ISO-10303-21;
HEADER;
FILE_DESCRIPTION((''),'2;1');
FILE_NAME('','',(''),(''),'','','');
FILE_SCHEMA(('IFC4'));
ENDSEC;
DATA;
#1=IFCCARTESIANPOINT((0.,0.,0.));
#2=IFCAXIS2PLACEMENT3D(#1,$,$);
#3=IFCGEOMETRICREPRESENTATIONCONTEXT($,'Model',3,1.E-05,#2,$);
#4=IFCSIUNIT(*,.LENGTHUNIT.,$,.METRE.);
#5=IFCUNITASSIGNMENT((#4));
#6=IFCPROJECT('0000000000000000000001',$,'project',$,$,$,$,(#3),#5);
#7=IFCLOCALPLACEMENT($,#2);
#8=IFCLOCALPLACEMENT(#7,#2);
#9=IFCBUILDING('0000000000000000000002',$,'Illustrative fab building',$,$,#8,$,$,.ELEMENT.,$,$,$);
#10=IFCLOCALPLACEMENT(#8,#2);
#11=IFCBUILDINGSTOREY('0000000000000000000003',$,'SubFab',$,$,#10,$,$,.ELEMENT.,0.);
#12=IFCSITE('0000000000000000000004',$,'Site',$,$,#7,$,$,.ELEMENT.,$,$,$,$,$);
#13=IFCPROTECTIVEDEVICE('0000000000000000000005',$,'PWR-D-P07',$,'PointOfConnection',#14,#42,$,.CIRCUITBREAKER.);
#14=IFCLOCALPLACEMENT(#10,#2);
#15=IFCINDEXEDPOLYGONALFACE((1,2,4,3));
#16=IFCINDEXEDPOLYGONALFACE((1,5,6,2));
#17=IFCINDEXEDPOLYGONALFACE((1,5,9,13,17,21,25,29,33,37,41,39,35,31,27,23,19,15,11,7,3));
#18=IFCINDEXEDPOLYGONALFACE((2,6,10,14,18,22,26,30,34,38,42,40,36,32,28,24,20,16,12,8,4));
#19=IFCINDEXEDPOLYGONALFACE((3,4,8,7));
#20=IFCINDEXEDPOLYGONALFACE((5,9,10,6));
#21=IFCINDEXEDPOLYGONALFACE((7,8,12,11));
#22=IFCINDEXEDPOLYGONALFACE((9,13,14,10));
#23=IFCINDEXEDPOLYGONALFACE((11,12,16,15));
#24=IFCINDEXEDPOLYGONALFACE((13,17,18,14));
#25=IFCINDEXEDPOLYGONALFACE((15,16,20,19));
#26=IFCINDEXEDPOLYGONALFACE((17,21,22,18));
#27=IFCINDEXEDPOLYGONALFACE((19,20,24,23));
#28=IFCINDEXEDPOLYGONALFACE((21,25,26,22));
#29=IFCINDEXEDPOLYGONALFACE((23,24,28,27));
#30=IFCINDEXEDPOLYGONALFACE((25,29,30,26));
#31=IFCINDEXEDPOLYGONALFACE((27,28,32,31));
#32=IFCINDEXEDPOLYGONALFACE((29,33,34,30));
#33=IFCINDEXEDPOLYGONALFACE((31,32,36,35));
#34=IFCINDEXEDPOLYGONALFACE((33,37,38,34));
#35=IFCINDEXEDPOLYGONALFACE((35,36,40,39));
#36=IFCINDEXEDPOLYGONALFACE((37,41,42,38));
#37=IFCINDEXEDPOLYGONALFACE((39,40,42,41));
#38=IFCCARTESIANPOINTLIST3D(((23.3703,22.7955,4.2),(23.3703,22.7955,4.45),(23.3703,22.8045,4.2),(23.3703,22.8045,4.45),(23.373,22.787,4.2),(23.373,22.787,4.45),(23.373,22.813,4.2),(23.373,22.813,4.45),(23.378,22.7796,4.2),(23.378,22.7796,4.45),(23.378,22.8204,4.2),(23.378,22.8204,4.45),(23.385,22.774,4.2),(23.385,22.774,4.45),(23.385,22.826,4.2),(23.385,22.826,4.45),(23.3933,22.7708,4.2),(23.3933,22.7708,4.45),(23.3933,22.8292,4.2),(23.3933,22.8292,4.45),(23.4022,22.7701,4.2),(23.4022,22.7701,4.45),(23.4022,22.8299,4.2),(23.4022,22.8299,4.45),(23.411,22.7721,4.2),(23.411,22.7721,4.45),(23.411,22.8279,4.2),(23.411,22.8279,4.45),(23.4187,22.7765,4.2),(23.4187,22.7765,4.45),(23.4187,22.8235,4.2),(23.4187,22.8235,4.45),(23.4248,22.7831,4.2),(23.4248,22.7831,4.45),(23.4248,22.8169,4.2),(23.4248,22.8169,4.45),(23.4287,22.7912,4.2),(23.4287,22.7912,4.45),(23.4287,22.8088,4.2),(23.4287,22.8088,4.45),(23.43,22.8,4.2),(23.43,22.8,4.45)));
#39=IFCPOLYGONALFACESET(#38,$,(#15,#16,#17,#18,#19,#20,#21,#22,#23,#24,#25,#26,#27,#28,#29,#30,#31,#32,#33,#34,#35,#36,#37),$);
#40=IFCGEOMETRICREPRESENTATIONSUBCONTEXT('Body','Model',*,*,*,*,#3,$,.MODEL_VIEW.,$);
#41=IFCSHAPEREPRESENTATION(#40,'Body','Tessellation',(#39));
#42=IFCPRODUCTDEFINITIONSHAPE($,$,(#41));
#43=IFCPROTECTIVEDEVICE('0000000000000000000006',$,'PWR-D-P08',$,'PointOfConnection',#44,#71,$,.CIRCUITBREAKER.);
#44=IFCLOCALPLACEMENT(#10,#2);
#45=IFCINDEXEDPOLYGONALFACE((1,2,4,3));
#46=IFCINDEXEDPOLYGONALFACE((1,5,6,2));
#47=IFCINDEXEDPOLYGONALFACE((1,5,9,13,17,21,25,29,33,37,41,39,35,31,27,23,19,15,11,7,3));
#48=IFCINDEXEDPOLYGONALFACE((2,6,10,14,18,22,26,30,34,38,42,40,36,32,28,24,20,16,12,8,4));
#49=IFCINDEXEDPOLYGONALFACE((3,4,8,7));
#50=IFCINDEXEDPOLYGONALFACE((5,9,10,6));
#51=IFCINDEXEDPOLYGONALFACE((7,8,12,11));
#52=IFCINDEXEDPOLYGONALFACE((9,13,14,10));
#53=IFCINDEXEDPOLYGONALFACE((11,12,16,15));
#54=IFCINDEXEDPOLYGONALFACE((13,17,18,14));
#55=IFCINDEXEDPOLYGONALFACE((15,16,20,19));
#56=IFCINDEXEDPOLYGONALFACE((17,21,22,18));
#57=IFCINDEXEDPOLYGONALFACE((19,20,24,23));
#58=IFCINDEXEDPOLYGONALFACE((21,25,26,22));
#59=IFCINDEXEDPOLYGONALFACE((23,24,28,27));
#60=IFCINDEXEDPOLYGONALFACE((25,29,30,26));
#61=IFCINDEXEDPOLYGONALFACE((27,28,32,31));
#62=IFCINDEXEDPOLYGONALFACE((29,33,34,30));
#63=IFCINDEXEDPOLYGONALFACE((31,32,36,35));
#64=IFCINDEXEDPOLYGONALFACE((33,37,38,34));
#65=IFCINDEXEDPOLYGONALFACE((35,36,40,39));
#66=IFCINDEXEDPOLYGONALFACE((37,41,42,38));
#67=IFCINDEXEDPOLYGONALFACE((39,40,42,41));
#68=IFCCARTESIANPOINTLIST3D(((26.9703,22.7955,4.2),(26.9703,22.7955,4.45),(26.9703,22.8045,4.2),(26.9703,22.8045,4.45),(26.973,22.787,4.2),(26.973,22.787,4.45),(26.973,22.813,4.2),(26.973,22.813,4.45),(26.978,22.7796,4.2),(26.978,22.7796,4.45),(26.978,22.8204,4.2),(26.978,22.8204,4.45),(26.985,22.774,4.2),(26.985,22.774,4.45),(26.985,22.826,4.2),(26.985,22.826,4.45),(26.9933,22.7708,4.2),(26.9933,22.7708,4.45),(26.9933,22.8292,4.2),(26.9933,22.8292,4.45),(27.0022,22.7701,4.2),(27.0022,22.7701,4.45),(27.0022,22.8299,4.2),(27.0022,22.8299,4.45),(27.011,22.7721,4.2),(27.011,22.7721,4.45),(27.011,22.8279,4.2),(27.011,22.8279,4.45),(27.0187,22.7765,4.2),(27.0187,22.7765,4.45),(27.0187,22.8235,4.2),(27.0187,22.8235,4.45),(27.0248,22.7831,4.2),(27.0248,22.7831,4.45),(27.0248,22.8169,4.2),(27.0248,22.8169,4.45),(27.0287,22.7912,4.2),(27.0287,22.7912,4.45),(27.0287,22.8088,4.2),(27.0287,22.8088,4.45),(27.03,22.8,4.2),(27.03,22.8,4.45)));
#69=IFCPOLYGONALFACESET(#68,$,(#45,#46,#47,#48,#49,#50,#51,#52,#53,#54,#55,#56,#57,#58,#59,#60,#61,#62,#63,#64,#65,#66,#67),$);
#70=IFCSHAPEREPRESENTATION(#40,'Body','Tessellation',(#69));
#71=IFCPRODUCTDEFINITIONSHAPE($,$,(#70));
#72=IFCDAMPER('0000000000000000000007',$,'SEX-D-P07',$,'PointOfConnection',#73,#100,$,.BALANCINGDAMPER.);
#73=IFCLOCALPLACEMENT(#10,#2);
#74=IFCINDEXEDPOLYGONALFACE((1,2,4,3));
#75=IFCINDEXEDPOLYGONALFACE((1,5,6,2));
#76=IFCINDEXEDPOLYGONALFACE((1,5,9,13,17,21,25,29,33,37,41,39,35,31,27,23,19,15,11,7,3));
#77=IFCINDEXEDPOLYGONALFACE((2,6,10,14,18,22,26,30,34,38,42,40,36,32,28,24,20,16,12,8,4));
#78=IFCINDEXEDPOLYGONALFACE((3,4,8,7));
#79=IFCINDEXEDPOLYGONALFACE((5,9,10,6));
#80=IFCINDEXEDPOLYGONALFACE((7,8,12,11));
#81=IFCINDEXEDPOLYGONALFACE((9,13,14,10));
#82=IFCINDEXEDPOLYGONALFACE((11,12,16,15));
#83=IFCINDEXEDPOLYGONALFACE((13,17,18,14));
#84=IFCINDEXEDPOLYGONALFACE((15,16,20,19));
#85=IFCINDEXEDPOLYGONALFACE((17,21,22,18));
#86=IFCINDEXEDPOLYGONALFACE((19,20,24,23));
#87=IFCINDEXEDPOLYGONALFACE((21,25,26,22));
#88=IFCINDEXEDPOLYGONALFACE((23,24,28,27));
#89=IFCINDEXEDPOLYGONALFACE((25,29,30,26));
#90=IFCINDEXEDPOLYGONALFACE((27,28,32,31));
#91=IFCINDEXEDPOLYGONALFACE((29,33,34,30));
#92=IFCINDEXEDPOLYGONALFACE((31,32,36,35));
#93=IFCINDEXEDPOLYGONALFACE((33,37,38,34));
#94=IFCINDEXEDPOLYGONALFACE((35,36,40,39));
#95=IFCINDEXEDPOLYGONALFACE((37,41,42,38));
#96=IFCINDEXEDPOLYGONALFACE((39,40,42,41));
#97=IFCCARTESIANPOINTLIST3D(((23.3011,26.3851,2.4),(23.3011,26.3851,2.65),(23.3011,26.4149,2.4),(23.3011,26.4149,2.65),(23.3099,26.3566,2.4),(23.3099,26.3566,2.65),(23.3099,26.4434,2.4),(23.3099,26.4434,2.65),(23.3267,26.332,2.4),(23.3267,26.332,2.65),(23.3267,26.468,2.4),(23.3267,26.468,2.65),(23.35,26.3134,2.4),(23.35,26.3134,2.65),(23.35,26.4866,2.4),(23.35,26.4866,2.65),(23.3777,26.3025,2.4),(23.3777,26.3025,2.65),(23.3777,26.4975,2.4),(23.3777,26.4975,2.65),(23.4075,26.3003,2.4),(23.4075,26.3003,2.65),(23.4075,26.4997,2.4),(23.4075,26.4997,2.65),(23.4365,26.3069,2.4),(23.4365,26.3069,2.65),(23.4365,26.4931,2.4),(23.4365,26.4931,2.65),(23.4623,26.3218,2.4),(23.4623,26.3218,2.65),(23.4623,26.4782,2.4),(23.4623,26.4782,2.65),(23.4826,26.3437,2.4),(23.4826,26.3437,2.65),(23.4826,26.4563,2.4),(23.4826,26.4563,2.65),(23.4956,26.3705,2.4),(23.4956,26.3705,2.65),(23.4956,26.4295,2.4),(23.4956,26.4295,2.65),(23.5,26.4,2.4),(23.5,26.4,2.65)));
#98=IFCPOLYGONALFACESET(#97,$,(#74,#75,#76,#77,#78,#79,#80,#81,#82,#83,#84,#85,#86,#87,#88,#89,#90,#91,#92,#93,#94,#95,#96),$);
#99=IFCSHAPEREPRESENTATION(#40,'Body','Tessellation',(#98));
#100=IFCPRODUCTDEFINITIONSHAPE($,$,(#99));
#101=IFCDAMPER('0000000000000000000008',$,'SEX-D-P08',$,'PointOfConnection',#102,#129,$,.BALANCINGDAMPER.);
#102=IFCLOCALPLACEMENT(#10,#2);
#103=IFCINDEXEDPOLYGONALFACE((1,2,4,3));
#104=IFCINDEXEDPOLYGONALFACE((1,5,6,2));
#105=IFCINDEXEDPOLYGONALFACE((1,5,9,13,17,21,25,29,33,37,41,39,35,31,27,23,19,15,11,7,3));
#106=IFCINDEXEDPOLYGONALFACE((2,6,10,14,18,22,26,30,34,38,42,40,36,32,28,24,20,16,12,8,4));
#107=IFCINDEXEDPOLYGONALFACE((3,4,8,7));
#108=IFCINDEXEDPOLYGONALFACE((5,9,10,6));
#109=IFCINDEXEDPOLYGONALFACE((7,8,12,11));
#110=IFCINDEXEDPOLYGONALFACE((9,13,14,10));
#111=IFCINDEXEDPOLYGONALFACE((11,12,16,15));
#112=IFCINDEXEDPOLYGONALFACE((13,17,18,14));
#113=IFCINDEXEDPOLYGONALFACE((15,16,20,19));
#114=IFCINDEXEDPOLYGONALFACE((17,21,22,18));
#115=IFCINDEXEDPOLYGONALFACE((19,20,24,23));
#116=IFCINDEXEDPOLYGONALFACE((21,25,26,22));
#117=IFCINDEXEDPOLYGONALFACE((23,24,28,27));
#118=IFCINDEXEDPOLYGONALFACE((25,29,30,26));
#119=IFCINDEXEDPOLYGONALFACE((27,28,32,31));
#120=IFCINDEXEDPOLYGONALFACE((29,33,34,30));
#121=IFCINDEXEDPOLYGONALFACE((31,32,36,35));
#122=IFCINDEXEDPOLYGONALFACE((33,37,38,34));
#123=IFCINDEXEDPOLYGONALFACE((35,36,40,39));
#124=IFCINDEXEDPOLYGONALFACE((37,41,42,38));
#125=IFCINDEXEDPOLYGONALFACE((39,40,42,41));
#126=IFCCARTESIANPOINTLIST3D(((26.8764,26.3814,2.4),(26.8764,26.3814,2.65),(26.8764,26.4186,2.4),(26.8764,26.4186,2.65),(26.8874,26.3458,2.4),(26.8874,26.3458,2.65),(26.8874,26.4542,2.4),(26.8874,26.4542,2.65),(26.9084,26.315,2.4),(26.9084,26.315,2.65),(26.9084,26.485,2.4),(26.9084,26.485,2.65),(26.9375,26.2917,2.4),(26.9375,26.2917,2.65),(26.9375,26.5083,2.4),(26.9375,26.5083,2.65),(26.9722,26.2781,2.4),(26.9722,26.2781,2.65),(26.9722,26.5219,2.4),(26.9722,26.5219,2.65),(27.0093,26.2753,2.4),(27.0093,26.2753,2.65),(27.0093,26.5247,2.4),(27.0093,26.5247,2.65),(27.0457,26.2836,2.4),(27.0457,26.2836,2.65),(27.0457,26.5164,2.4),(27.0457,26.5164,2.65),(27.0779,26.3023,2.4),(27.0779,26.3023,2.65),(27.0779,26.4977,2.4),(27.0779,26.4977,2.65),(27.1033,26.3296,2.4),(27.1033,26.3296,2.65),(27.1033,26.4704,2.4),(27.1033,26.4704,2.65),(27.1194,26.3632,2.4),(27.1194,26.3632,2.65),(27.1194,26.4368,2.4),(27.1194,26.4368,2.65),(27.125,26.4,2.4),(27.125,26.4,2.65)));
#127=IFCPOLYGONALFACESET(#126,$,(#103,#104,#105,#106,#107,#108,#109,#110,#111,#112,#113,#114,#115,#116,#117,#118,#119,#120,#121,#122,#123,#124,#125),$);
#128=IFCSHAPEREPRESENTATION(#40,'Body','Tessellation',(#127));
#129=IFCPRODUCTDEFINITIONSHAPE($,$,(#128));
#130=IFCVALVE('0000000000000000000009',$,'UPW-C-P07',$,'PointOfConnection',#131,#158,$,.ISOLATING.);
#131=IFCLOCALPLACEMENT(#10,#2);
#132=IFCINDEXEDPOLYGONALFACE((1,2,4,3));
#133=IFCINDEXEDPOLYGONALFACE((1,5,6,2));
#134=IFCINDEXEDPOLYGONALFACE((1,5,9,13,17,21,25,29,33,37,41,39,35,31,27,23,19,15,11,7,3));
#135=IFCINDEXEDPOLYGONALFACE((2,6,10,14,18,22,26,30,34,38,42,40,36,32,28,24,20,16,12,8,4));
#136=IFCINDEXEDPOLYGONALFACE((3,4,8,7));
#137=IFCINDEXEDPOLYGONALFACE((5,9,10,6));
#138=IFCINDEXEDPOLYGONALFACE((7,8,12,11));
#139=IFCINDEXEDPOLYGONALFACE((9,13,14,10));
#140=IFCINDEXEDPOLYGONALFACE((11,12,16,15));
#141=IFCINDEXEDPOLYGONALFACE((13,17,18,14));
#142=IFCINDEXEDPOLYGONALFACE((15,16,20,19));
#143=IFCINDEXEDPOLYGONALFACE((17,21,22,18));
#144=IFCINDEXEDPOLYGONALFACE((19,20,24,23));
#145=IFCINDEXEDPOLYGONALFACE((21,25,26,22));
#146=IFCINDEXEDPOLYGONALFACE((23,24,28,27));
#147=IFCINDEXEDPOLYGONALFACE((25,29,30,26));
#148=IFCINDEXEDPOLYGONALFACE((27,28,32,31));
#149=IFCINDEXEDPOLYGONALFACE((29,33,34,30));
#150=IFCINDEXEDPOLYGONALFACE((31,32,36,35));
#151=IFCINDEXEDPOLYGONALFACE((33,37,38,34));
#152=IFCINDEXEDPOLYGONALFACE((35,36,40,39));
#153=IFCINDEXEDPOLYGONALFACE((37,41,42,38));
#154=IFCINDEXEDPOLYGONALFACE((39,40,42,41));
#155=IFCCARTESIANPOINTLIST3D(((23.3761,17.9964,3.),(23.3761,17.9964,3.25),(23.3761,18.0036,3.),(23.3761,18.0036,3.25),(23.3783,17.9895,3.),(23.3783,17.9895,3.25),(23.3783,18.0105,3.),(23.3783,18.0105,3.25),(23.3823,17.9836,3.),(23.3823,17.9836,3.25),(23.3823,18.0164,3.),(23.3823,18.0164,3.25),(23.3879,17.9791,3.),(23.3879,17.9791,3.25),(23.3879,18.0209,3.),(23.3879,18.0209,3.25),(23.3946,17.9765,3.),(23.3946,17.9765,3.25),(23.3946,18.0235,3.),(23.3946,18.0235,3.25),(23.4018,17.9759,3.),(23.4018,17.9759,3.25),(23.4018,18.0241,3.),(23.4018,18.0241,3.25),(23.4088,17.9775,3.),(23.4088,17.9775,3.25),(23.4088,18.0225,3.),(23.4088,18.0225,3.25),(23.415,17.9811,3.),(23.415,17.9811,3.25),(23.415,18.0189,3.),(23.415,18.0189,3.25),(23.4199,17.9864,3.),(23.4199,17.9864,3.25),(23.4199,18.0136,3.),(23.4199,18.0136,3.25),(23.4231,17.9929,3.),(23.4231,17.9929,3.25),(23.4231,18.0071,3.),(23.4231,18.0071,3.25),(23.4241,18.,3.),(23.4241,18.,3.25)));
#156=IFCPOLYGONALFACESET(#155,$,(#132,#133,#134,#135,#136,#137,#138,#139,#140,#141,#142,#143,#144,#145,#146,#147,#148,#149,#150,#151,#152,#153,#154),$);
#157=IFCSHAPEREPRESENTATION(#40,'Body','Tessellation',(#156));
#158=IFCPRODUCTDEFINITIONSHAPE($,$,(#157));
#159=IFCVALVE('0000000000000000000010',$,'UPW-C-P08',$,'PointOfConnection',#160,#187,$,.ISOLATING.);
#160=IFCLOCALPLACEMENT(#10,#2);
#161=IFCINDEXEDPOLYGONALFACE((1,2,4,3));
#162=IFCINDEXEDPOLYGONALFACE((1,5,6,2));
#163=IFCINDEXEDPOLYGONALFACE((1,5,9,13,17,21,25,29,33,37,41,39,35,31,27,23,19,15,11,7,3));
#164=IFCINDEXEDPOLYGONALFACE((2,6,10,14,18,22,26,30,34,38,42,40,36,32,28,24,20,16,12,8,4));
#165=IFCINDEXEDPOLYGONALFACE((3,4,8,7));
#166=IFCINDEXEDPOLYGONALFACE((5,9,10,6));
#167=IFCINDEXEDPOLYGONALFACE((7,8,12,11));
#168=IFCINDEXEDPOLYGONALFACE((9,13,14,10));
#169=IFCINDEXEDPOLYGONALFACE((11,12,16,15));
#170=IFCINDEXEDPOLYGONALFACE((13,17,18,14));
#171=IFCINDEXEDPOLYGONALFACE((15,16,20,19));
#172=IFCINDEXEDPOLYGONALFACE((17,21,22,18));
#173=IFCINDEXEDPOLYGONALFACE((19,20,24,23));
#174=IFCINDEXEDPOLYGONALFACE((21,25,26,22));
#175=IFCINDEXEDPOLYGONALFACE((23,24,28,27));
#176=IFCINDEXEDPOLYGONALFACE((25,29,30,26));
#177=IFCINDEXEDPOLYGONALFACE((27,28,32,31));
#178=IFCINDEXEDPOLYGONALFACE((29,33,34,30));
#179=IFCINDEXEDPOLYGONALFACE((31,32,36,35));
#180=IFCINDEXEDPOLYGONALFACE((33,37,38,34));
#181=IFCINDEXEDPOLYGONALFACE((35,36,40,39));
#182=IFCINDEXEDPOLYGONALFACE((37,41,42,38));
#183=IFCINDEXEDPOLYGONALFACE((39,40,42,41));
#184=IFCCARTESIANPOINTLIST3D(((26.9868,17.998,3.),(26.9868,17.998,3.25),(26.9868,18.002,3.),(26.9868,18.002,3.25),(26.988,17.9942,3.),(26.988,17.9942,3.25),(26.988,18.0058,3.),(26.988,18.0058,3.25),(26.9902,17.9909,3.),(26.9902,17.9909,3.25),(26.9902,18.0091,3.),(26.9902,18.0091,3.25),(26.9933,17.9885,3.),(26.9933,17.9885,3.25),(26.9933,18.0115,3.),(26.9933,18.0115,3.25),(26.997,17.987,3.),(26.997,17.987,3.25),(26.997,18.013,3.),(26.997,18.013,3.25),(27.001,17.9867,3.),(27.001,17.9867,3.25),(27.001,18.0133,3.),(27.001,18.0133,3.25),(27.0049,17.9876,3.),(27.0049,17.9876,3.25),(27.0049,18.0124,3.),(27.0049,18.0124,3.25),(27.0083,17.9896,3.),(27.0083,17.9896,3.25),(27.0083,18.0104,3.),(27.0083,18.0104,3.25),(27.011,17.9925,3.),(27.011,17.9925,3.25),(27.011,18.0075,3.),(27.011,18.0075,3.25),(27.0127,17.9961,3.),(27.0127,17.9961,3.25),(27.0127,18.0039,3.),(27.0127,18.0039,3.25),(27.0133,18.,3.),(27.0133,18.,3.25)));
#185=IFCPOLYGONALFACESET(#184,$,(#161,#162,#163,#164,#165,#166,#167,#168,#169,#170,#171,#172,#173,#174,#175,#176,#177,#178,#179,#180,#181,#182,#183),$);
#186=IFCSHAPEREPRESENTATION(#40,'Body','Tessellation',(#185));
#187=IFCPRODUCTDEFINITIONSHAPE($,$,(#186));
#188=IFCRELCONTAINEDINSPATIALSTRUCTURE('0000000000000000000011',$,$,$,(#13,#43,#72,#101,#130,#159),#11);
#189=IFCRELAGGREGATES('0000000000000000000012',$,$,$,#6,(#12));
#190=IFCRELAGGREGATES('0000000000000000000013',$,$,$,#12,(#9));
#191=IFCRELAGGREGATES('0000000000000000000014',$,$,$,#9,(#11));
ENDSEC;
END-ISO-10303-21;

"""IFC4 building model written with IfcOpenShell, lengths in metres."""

from ifc_helpers import new_model, entity, si_unit, frame, origin, place, context, subcontext, project, spatial, element, save


model = new_model("IFC4")

# Units and contexts
model_context = context("Model", 3, precision=1e-05, world=origin())
body_context = subcontext(model_context, "Body", "Model", "MODEL_VIEW")
ifc_project = project(units=[si_unit("LENGTHUNIT", "METRE")], contexts=[model_context])

# Site, building, storey
site_placement = place(None, origin())
site = spatial("IfcSite", under=ifc_project, at=site_placement, Name="Site", CompositionType="ELEMENT")
building_placement = place(site_placement, origin())
building = spatial("IfcBuilding", under=site, at=building_placement, Name="Illustrative fab building", CompositionType="ELEMENT")
storey_placement = place(building_placement, origin())
storey = spatial("IfcBuildingStorey", under=building, at=storey_placement, Name="SubFab", CompositionType="ELEMENT", Elevation=0.0)

# Protective devices
for number, where, name in (
    (1, (23.4, 22.8, 4.2), "PWR-D-P07"),
    (2, (27.0, 22.8, 4.2), "PWR-D-P08"),
):
    element("IfcProtectiveDevice", number, at=place(storey_placement, frame(where)), inside=storey, Name=name, ObjectType="PointOfConnection", PredefinedType="CIRCUITBREAKER", context=body_context, shape_type="AdvancedSweptSolid", body=[
        entity("IfcSweptDiskSolid", entity("IfcPolyline", [entity("IfcCartesianPoint", [0.0, 0.0, 0.0]), entity("IfcCartesianPoint", [0.0, 0.0, 0.25])]), 0.03),
    ])

# Dampers
damper_1_placement = place(storey_placement, frame((23.4, 26.4, 2.4)))
element("IfcDamper", 3, at=damper_1_placement, inside=storey, Name="SEX-D-P07", ObjectType="PointOfConnection", PredefinedType="BALANCINGDAMPER", context=body_context, shape_type="AdvancedSweptSolid", body=[
    entity("IfcSweptDiskSolid", entity("IfcPolyline", [entity("IfcCartesianPoint", [0.0, 0.0, 0.0]), entity("IfcCartesianPoint", [0.0, 0.0, 0.25])]), 0.1),
])
damper_2_placement = place(storey_placement, frame((27.0, 26.4, 2.4)))
element("IfcDamper", 4, at=damper_2_placement, inside=storey, Name="SEX-D-P08", ObjectType="PointOfConnection", PredefinedType="BALANCINGDAMPER", context=body_context, shape_type="AdvancedSweptSolid", body=[
    entity("IfcSweptDiskSolid", entity("IfcPolyline", [entity("IfcCartesianPoint", [0.0, 0.0, 0.0]), entity("IfcCartesianPoint", [0.0, 0.0, 0.25])]), 0.125),
])

# Valves
valve_1_placement = place(storey_placement, frame((23.4, 18.0, 3.0)))
element("IfcValve", 5, at=valve_1_placement, inside=storey, Name="UPW-C-P07", ObjectType="PointOfConnection", PredefinedType="ISOLATING", context=body_context, shape_type="AdvancedSweptSolid", body=[
    entity("IfcSweptDiskSolid", entity("IfcPolyline", [entity("IfcCartesianPoint", [0.0, 0.0, 0.0]), entity("IfcCartesianPoint", [0.0, 0.0, 0.25])]), 0.0241),
])
valve_2_placement = place(storey_placement, frame((27.0, 18.0, 3.0)))
element("IfcValve", 6, at=valve_2_placement, inside=storey, Name="UPW-C-P08", ObjectType="PointOfConnection", PredefinedType="ISOLATING", context=body_context, shape_type="AdvancedSweptSolid", body=[
    entity("IfcSweptDiskSolid", entity("IfcPolyline", [entity("IfcCartesianPoint", [0.0, 0.0, 0.0]), entity("IfcCartesianPoint", [0.0, 0.0, 0.25])]), 0.0133),
])

save(model, "model.ifc")
